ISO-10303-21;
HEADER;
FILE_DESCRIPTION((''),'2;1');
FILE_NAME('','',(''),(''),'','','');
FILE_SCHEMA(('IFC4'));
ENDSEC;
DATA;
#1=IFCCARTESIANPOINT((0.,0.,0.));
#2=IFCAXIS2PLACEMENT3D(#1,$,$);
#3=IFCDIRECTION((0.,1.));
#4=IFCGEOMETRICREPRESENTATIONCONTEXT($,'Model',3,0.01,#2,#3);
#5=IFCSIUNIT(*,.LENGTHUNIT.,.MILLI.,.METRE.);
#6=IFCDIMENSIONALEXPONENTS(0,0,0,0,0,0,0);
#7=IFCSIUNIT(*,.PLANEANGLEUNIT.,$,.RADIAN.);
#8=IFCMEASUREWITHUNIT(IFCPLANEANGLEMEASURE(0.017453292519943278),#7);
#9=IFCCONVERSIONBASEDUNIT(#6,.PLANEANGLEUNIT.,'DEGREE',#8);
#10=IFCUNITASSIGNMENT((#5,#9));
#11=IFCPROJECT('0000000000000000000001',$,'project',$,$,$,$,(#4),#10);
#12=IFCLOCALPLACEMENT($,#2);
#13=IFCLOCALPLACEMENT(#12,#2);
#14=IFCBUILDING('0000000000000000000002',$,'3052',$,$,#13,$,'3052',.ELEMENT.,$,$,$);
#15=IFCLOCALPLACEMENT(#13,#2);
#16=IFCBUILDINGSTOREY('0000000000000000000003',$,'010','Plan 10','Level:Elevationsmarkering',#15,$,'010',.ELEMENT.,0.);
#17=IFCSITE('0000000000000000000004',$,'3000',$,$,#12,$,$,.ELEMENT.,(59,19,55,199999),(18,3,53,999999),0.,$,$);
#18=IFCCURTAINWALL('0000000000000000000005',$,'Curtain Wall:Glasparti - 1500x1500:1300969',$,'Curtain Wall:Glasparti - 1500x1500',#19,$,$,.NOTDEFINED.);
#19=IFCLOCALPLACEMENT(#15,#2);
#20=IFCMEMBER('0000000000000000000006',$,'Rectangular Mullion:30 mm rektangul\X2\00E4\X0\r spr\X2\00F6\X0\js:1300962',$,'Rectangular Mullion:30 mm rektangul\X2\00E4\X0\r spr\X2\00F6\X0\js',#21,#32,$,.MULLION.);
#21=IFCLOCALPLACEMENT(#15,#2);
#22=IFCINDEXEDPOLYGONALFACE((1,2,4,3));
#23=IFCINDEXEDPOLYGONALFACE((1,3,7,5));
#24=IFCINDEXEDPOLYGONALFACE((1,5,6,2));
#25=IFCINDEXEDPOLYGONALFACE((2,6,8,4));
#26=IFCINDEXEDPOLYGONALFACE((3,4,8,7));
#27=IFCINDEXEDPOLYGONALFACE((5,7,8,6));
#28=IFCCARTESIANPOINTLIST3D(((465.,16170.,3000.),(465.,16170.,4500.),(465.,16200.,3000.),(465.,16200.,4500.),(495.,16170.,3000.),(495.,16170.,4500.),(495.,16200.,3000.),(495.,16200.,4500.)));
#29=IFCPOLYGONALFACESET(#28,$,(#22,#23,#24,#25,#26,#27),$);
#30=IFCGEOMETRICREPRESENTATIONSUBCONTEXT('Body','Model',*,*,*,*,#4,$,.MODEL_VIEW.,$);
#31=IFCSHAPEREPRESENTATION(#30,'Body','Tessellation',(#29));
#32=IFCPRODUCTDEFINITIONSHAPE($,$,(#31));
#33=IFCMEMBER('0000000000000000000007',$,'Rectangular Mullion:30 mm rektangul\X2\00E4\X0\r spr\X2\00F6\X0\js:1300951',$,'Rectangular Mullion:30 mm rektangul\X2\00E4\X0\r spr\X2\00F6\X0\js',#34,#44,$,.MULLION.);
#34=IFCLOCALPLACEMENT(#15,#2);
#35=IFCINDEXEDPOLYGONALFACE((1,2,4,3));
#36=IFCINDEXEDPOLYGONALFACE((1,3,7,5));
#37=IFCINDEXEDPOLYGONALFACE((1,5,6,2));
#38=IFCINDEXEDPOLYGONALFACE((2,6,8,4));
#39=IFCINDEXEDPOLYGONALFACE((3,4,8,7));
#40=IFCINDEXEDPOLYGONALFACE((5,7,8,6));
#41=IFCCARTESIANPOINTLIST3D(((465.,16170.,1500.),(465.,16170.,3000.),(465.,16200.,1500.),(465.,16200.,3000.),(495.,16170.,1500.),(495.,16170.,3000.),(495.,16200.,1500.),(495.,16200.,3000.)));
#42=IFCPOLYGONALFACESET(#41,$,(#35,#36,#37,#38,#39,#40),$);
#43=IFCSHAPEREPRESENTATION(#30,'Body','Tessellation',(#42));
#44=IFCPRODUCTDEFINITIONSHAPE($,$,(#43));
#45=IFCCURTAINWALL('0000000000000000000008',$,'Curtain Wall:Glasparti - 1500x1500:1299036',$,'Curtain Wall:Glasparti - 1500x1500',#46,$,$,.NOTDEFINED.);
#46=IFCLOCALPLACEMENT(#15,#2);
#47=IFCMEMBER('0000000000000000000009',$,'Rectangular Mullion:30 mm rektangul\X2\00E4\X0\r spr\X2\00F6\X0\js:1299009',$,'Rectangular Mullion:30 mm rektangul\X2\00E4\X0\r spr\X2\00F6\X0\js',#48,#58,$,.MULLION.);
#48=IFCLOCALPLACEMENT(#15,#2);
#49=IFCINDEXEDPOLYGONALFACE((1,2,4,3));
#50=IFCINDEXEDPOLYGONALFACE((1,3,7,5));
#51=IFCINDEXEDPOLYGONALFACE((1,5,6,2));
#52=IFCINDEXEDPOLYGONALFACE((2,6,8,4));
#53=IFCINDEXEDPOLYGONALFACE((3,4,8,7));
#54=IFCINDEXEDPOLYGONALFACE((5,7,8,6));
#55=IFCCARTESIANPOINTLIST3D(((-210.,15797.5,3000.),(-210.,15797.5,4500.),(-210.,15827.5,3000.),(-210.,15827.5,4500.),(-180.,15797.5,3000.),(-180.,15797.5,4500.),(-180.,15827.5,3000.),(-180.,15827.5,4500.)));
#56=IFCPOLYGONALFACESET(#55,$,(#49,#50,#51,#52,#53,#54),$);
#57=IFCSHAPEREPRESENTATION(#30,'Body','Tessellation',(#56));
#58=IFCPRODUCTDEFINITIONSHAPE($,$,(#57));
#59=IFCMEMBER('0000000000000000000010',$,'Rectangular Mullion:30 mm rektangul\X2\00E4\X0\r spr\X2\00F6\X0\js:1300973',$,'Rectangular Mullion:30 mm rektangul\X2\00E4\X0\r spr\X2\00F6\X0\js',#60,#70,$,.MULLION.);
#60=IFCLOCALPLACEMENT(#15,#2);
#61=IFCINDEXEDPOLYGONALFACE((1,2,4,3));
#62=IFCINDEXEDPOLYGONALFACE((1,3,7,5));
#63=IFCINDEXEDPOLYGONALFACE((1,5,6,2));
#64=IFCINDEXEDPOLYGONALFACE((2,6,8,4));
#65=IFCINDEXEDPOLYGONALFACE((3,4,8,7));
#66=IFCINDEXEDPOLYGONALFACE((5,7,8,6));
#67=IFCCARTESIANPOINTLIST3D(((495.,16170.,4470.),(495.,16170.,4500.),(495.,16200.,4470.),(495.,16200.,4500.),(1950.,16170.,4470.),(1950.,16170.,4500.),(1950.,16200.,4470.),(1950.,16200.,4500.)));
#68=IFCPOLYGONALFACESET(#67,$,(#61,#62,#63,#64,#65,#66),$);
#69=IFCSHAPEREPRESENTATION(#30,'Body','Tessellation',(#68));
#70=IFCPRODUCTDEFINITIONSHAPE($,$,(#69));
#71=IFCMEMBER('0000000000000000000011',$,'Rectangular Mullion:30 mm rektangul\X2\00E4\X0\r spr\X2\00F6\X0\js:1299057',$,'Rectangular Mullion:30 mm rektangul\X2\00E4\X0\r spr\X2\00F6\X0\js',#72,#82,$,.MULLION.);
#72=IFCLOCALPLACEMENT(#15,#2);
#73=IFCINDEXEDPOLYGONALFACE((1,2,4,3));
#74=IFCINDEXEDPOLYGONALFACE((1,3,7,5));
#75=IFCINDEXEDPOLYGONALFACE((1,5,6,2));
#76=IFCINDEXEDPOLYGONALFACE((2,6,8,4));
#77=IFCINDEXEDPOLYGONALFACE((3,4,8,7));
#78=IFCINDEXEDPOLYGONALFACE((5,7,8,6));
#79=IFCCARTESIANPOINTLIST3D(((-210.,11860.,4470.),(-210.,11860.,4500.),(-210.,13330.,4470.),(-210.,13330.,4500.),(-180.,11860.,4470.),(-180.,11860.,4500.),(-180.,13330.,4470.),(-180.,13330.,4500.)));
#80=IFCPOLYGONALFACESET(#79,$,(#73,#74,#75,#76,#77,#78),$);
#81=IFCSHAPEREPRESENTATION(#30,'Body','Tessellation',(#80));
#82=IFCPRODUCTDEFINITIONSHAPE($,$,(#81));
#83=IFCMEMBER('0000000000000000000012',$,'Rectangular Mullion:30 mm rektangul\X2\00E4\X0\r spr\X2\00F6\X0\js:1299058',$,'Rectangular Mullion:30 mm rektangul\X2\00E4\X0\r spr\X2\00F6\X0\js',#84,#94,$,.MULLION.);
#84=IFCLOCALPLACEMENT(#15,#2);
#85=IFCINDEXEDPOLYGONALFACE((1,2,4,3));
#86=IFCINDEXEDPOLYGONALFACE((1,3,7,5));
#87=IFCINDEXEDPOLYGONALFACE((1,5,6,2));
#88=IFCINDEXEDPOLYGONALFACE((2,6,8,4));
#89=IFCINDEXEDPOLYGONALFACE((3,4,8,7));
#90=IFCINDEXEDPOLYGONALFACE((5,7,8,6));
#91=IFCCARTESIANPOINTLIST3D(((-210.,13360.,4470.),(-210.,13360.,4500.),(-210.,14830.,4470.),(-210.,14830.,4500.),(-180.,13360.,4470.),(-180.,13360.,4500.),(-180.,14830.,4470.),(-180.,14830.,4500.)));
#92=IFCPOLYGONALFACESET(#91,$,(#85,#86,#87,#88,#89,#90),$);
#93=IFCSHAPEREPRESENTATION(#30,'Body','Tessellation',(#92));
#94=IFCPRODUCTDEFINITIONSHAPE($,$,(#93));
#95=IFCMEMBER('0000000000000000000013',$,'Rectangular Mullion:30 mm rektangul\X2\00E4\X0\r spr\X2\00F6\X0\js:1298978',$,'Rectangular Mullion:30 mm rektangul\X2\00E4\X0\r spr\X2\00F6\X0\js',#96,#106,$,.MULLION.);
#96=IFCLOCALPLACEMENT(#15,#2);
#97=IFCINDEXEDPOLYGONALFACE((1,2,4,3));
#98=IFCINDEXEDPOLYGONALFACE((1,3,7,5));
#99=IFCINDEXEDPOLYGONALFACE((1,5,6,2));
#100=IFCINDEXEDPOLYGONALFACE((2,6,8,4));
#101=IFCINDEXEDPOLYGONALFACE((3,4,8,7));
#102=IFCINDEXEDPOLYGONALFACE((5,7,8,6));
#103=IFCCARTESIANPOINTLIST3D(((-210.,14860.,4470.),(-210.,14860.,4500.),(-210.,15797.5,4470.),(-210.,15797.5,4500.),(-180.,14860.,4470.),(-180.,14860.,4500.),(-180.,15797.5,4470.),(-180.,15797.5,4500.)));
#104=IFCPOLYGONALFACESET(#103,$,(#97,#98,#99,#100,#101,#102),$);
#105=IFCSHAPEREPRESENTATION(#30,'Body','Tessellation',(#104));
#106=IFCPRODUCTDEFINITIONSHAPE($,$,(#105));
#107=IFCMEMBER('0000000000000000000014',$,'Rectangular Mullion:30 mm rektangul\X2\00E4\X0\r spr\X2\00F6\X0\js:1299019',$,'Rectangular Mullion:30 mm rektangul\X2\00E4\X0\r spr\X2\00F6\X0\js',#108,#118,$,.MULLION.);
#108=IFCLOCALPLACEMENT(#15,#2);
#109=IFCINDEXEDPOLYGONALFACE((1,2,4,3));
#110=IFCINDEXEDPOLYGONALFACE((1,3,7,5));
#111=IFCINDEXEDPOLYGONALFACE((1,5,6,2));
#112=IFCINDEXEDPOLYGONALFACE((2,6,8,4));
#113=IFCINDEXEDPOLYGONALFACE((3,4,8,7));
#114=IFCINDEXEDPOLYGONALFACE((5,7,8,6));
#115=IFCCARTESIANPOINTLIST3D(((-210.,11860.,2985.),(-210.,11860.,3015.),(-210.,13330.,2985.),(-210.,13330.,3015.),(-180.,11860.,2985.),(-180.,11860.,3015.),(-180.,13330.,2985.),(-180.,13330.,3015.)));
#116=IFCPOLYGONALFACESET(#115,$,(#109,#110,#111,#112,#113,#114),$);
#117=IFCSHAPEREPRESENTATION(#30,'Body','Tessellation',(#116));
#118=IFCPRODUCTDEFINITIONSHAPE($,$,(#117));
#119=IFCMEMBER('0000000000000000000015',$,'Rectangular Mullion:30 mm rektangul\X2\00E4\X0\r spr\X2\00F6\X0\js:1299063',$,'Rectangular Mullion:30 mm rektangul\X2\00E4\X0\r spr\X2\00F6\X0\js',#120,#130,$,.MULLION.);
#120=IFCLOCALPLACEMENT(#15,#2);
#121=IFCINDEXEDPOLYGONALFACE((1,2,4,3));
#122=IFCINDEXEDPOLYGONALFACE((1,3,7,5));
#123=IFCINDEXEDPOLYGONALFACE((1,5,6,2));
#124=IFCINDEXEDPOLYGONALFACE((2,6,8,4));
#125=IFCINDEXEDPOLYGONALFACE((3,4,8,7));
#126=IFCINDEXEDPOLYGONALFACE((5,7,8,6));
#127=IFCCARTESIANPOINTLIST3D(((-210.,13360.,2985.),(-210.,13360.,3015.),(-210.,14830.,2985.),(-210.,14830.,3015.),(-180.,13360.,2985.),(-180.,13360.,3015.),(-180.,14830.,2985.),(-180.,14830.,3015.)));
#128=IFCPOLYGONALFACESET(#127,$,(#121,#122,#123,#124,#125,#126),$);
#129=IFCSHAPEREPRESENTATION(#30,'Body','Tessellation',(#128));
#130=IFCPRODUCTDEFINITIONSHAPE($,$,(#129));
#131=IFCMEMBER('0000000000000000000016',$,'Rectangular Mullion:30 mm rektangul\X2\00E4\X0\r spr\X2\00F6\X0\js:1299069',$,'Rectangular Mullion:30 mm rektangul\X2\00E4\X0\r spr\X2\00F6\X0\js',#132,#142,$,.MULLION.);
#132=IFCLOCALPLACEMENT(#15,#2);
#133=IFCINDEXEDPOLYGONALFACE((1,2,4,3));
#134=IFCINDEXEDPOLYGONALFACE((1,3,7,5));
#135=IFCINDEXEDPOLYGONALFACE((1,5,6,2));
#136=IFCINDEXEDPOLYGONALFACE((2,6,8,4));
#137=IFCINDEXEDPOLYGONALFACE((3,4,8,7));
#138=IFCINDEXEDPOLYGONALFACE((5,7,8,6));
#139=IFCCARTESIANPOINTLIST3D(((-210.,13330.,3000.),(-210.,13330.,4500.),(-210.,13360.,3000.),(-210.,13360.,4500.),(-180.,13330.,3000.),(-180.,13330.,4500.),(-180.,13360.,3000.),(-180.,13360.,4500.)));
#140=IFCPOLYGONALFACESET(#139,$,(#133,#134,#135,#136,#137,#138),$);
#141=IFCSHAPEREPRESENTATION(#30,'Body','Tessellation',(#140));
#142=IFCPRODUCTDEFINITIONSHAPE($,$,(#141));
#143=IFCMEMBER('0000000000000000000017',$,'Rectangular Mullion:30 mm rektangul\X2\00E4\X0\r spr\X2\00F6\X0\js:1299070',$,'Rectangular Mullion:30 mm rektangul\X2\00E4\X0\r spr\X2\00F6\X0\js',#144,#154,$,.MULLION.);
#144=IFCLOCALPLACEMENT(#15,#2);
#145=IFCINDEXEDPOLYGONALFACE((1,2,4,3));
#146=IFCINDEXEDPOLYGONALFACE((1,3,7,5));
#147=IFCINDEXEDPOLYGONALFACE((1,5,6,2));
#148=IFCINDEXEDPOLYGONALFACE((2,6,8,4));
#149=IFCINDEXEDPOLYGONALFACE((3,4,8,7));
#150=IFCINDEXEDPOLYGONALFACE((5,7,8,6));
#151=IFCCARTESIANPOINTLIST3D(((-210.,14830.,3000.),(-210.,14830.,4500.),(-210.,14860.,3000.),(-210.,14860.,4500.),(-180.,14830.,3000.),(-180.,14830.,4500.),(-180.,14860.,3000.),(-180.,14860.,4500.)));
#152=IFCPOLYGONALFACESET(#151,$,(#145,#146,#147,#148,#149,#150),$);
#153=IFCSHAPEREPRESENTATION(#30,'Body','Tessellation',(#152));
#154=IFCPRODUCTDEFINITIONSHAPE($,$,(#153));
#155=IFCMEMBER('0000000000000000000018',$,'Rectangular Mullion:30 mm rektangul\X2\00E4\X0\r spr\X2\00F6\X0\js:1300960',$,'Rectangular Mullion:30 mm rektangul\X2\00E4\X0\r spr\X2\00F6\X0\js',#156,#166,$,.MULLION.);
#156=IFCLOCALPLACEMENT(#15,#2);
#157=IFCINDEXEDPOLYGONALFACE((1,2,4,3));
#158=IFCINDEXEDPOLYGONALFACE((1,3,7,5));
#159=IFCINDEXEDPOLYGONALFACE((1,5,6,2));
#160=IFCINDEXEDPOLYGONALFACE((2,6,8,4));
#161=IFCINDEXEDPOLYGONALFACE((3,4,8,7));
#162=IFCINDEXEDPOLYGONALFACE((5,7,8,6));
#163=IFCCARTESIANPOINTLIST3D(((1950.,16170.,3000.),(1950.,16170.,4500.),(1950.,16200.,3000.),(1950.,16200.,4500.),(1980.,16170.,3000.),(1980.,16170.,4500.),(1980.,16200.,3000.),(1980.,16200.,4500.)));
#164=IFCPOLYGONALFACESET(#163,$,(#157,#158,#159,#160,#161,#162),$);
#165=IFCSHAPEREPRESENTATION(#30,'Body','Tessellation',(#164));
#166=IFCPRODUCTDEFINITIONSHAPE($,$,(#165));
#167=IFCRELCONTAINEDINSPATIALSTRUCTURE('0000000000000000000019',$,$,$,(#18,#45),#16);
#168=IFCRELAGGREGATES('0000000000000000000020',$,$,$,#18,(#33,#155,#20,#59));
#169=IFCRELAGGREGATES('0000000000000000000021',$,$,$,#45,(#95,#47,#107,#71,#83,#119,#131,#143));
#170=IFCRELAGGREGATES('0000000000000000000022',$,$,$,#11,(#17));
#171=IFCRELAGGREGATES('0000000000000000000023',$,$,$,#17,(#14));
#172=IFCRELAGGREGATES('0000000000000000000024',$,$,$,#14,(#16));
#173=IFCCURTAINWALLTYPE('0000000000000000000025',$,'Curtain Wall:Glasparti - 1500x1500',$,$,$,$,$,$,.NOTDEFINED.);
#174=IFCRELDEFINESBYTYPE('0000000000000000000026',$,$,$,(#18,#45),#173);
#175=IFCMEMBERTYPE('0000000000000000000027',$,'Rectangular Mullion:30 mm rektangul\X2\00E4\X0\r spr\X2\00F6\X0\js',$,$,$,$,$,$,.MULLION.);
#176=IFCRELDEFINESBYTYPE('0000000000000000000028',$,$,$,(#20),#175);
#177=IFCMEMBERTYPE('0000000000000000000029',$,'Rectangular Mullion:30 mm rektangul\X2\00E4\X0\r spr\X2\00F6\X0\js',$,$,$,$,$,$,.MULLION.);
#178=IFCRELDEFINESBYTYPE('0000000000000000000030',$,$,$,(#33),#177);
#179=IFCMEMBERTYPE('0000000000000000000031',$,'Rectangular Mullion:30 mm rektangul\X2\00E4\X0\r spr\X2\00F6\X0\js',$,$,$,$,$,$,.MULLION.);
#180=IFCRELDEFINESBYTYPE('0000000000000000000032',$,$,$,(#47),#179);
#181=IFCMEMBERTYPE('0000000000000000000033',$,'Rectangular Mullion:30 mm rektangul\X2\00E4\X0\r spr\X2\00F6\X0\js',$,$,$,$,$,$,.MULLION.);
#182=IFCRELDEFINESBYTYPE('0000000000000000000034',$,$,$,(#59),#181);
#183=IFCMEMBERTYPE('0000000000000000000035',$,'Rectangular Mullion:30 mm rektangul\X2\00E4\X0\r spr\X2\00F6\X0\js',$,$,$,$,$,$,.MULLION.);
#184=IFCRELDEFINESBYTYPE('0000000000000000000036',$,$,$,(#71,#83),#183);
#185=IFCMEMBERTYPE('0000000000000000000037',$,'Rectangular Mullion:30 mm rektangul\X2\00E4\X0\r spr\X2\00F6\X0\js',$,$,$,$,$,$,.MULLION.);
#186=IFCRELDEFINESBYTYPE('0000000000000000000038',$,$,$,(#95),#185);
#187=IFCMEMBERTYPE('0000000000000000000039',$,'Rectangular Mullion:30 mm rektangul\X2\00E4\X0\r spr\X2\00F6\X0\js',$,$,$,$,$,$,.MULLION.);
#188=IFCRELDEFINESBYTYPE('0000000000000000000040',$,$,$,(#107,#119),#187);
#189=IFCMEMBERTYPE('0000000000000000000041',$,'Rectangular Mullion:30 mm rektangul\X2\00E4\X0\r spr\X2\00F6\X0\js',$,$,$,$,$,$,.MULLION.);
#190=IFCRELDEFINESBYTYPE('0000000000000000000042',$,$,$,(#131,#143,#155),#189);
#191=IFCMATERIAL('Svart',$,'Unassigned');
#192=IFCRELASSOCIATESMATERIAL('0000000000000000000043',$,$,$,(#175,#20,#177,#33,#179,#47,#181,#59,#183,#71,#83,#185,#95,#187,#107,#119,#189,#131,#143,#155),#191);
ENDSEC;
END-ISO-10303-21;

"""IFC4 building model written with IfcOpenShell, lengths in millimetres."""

from ifc_helpers import new_model, entity, si_unit, converted_unit, direction, frame, origin, place, context, subcontext, project, spatial, indexed_curve, outline, extrude, source, transform, mapped, material, type_object, type_shapes, element, aggregate, save


model = new_model("IFC4")

# Units and contexts
model_context = context("Model", 3, precision=0.01, world=origin(), true_north=direction((0.0, 1.0)))
body_context = subcontext(model_context, "Body", "Model", "MODEL_VIEW")
ifc_project = project(units=[si_unit("LENGTHUNIT", "METRE", prefix="MILLI"), converted_unit("PLANEANGLEUNIT", "DEGREE", entity("IfcPlaneAngleMeasure", 0.017453292519943278), si_unit("PLANEANGLEUNIT", "RADIAN"), dimensions=[0, 0, 0, 0, 0, 0, 0])], contexts=[model_context])

# Site, building, storey
site_placement = place(None, origin())
site = spatial("IfcSite", under=ifc_project, at=site_placement, Name="3000", CompositionType="ELEMENT", RefLatitude=(59, 19, 55, 199999), RefLongitude=(18, 3, 53, 999999), RefElevation=0.0)
building_placement = place(site_placement, origin())
building = spatial("IfcBuilding", under=site, at=building_placement, Name="3052", LongName="3052", CompositionType="ELEMENT")
storey_placement = place(building_placement, origin())
storey = spatial("IfcBuildingStorey", under=building, at=storey_placement, Name="010", Description="Plan 10", ObjectType="Level:Elevationsmarkering", LongName="010", CompositionType="ELEMENT", Elevation=0.0)

# Curtain wall, members
curtain_wall_type = type_object("IfcCurtainWallType", Name="Curtain Wall:Glasparti - 1500x1500", PredefinedType="NOTDEFINED")
curtain_wall_1_placement = place(storey_placement, origin())
curtain_wall_1 = element("IfcCurtainWall", 1, at=curtain_wall_1_placement, inside=storey, type_object=curtain_wall_type, Name="Curtain Wall:Glasparti - 1500x1500:1300969", ObjectType="Curtain Wall:Glasparti - 1500x1500", PredefinedType="NOTDEFINED")
ifc_material_1 = material(Name="Svart", Category="Unassigned")
member_type_1 = type_object("IfcMemberType", Name="Rectangular Mullion:30 mm rektangulär spröjs", PredefinedType="MULLION", material=ifc_material_1)
shared_shape_1 = source(origin(), body_context, "Body", "SweptSolid", [
    extrude(outline(indexed_curve([(-15.0, -15.0), (15.0, -15.0), (15.0, 15.0), (-15.0, 15.0), (-15.0, -15.0)], self_intersect=False)), frame((-15.0, 0.0, -1500.0), z_axis=(0.0, 0.0, 1.0), x_axis=(-1.0, 0.0, 0.0)), (0.0, 0.0, 1.0), 1500.0),
])
type_shapes(member_type_1, [shared_shape_1])
member_1_placement = place(curtain_wall_1_placement, frame((465.0, 16185.0, 4500.0), z_axis=(0.0, 0.0, 1.0), x_axis=(-1.0, 0.0, 0.0)))
member_1 = element("IfcMember", 2, at=member_1_placement, type_object=member_type_1, material=ifc_material_1, Name="Rectangular Mullion:30 mm rektangulär spröjs:1300962", ObjectType="Rectangular Mullion:30 mm rektangulär spröjs", PredefinedType="MULLION", context=body_context, shape_type="MappedRepresentation", body=[
    mapped(shared_shape_1, transform((0.0, 0.0, 0.0), scale=1.0)),
])
member_type_2 = type_object("IfcMemberType", Name="Rectangular Mullion:30 mm rektangulär spröjs", PredefinedType="MULLION", material=ifc_material_1)
shared_shape_2 = source(origin(), body_context, "Body", "SweptSolid", [
    extrude(outline(indexed_curve([(-15.0, -15.0), (15.0, -15.0), (15.0, 15.0), (-15.0, 15.0), (-15.0, -15.0)], self_intersect=False)), frame((-15.0, 0.0, -1500.0), z_axis=(0.0, 0.0, 1.0), x_axis=(-1.0, 0.0, 0.0)), (0.0, 0.0, 1.0), 1500.0),
])
type_shapes(member_type_2, [shared_shape_2])
member_2_placement = place(curtain_wall_1_placement, frame((465.0, 16185.0, 3000.0), z_axis=(0.0, 0.0, 1.0), x_axis=(-1.0, 0.0, 0.0)))
member_2 = element("IfcMember", 3, at=member_2_placement, type_object=member_type_2, material=ifc_material_1, Name="Rectangular Mullion:30 mm rektangulär spröjs:1300951", ObjectType="Rectangular Mullion:30 mm rektangulär spröjs", PredefinedType="MULLION", context=body_context, shape_type="MappedRepresentation", body=[
    mapped(shared_shape_2, transform((0.0, 0.0, 0.0), scale=1.0)),
])

# Curtain wall, member
curtain_wall_2_placement = place(storey_placement, origin())
curtain_wall_2 = element("IfcCurtainWall", 4, at=curtain_wall_2_placement, inside=storey, type_object=curtain_wall_type, Name="Curtain Wall:Glasparti - 1500x1500:1299036", ObjectType="Curtain Wall:Glasparti - 1500x1500", PredefinedType="NOTDEFINED")
member_type_3 = type_object("IfcMemberType", Name="Rectangular Mullion:30 mm rektangulär spröjs", PredefinedType="MULLION", material=ifc_material_1)
shared_shape_3 = source(origin(), body_context, "Body", "SweptSolid", [
    extrude(outline(indexed_curve([(-15.0, -15.0), (15.0, -15.0), (15.0, 15.0), (-15.0, 15.0), (-15.0, -15.0)], self_intersect=False)), frame((-15.0, 0.0, -1500.0), z_axis=(0.0, 0.0, 1.0), x_axis=(-1.0, 0.0, 0.0)), (0.0, 0.0, 1.0), 1500.0),
])
type_shapes(member_type_3, [shared_shape_3])
member_3_placement = place(curtain_wall_2_placement, frame((-195.0, 15827.5, 3000.0), z_axis=(0.0, 0.0, -1.0), x_axis=(0.0, 1.0, 0.0)))
member_3 = element("IfcMember", 5, at=member_3_placement, type_object=member_type_3, material=ifc_material_1, Name="Rectangular Mullion:30 mm rektangulär spröjs:1299009", ObjectType="Rectangular Mullion:30 mm rektangulär spröjs", PredefinedType="MULLION", context=body_context, shape_type="MappedRepresentation", body=[
    mapped(shared_shape_3, transform((0.0, 0.0, 0.0), scale=1.0)),
])

# Members
member_type_4 = type_object("IfcMemberType", Name="Rectangular Mullion:30 mm rektangulär spröjs", PredefinedType="MULLION", material=ifc_material_1)
shared_shape_4 = source(origin(), body_context, "Body", "SweptSolid", [
    extrude(outline(indexed_curve([(-15.0, -15.0), (15.0, -15.0), (15.0, 15.0), (-15.0, 15.0), (-15.0, -15.0)], self_intersect=False)), frame((-15.0, 0.0, -1455.0), z_axis=(0.0, 0.0, 1.0), x_axis=(-1.0, 0.0, 0.0)), (0.0, 0.0, 1.0), 1455.0),
])
type_shapes(member_type_4, [shared_shape_4])
member_4_placement = place(curtain_wall_1_placement, frame((1950.0, 16185.0, 4500.0), z_axis=(1.0, 0.0, 0.0), x_axis=(0.0, 0.0, 1.0)))
member_4 = element("IfcMember", 6, at=member_4_placement, type_object=member_type_4, material=ifc_material_1, Name="Rectangular Mullion:30 mm rektangulär spröjs:1300973", ObjectType="Rectangular Mullion:30 mm rektangulär spröjs", PredefinedType="MULLION", context=body_context, shape_type="MappedRepresentation", body=[
    mapped(shared_shape_4, transform((0.0, 0.0, 0.0), scale=1.0)),
])
member_type_5 = type_object("IfcMemberType", Name="Rectangular Mullion:30 mm rektangulär spröjs", PredefinedType="MULLION", material=ifc_material_1)
shared_shape_5 = source(origin(), body_context, "Body", "SweptSolid", [
    extrude(outline(indexed_curve([(-15.0, -15.0), (15.0, -15.0), (15.0, 15.0), (-15.0, 15.0), (-15.0, -15.0)], self_intersect=False)), frame((-15.0, 0.0, -1470.0), z_axis=(0.0, 0.0, 1.0), x_axis=(-1.0, 0.0, 0.0)), (0.0, 0.0, 1.0), 1470.0),
])
type_shapes(member_type_5, [shared_shape_5])
member_5_placement = place(curtain_wall_2_placement, frame((-195.0, 13330.0, 4500.0), z_axis=(0.0, 1.0, 0.0), x_axis=(0.0, 0.0, 1.0)))
member_5 = element("IfcMember", 7, at=member_5_placement, type_object=member_type_5, material=ifc_material_1, Name="Rectangular Mullion:30 mm rektangulär spröjs:1299057", ObjectType="Rectangular Mullion:30 mm rektangulär spröjs", PredefinedType="MULLION", context=body_context, shape_type="MappedRepresentation", body=[
    mapped(shared_shape_5, transform((0.0, 0.0, 0.0), scale=1.0)),
])
member_6_placement = place(curtain_wall_2_placement, frame((-195.0, 14830.0, 4500.0), z_axis=(0.0, 1.0, 0.0), x_axis=(0.0, 0.0, 1.0)))
member_6 = element("IfcMember", 8, at=member_6_placement, type_object=member_type_5, material=ifc_material_1, Name="Rectangular Mullion:30 mm rektangulär spröjs:1299058", ObjectType="Rectangular Mullion:30 mm rektangulär spröjs", PredefinedType="MULLION", context=body_context, shape_type="MappedRepresentation", body=[
    mapped(shared_shape_5, transform((0.0, 0.0, 0.0), scale=1.0)),
])
member_type_6 = type_object("IfcMemberType", Name="Rectangular Mullion:30 mm rektangulär spröjs", PredefinedType="MULLION", material=ifc_material_1)
shared_shape_6 = source(origin(), body_context, "Body", "SweptSolid", [
    extrude(outline(indexed_curve([(-15.0, -15.0), (15.0, -15.0), (15.0, 15.0), (-15.0, 15.0), (-15.0, -15.0)], self_intersect=False)), frame((-15.0, 0.0, -937.5), z_axis=(0.0, 0.0, 1.0), x_axis=(-1.0, 0.0, 0.0)), (0.0, 0.0, 1.0), 937.5),
])
type_shapes(member_type_6, [shared_shape_6])
member_7_placement = place(curtain_wall_2_placement, frame((-195.0, 15797.5, 4500.0), z_axis=(0.0, 1.0, 0.0), x_axis=(0.0, 0.0, 1.0)))
member_7 = element("IfcMember", 9, at=member_7_placement, type_object=member_type_6, material=ifc_material_1, Name="Rectangular Mullion:30 mm rektangulär spröjs:1298978", ObjectType="Rectangular Mullion:30 mm rektangulär spröjs", PredefinedType="MULLION", context=body_context, shape_type="MappedRepresentation", body=[
    mapped(shared_shape_6, transform((0.0, 0.0, 0.0), scale=1.0)),
])
member_type_7 = type_object("IfcMemberType", Name="Rectangular Mullion:30 mm rektangulär spröjs", PredefinedType="MULLION", material=ifc_material_1)
shared_shape_7 = source(origin(), body_context, "Body", "SweptSolid", [
    extrude(outline(indexed_curve([(-15.0, -15.0), (15.0, -15.0), (15.0, 15.0), (-15.0, 15.0), (-15.0, -15.0)], self_intersect=False)), frame((0.0, 0.0, -1470.0), z_axis=(0.0, 0.0, 1.0), x_axis=(-1.0, 0.0, 0.0)), (0.0, 0.0, 1.0), 1470.0),
])
type_shapes(member_type_7, [shared_shape_7])
member_8_placement = place(curtain_wall_2_placement, frame((-195.0, 13330.0, 3000.0), z_axis=(0.0, 1.0, 0.0), x_axis=(0.0, 0.0, 1.0)))
member_8 = element("IfcMember", 10, at=member_8_placement, type_object=member_type_7, material=ifc_material_1, Name="Rectangular Mullion:30 mm rektangulär spröjs:1299019", ObjectType="Rectangular Mullion:30 mm rektangulär spröjs", PredefinedType="MULLION", context=body_context, shape_type="MappedRepresentation", body=[
    mapped(shared_shape_7, transform((0.0, 0.0, 0.0), scale=1.0)),
])
member_9_placement = place(curtain_wall_2_placement, frame((-195.0, 14830.0, 3000.0), z_axis=(0.0, 1.0, 0.0), x_axis=(0.0, 0.0, 1.0)))
member_9 = element("IfcMember", 11, at=member_9_placement, type_object=member_type_7, material=ifc_material_1, Name="Rectangular Mullion:30 mm rektangulär spröjs:1299063", ObjectType="Rectangular Mullion:30 mm rektangulär spröjs", PredefinedType="MULLION", context=body_context, shape_type="MappedRepresentation", body=[
    mapped(shared_shape_7, transform((0.0, 0.0, 0.0), scale=1.0)),
])
member_type_8 = type_object("IfcMemberType", Name="Rectangular Mullion:30 mm rektangulär spröjs", PredefinedType="MULLION", material=ifc_material_1)
shared_shape_8 = source(origin(), body_context, "Body", "SweptSolid", [
    extrude(outline(indexed_curve([(-15.0, -15.0), (15.0, -15.0), (15.0, 15.0), (-15.0, 15.0), (-15.0, -15.0)], self_intersect=False)), frame((0.0, 0.0, -1500.0), z_axis=(0.0, 0.0, 1.0), x_axis=(-1.0, 0.0, 0.0)), (0.0, 0.0, 1.0), 1500.0),
])
type_shapes(member_type_8, [shared_shape_8])
member_10_placement = place(curtain_wall_2_placement, frame((-195.0, 13345.0, 3000.0), z_axis=(0.0, 0.0, -1.0), x_axis=(0.0, 1.0, 0.0)))
member_10 = element("IfcMember", 12, at=member_10_placement, type_object=member_type_8, material=ifc_material_1, Name="Rectangular Mullion:30 mm rektangulär spröjs:1299069", ObjectType="Rectangular Mullion:30 mm rektangulär spröjs", PredefinedType="MULLION", context=body_context, shape_type="MappedRepresentation", body=[
    mapped(shared_shape_8, transform((0.0, 0.0, 0.0), scale=1.0)),
])
member_11_placement = place(curtain_wall_2_placement, frame((-195.0, 14845.0, 3000.0), z_axis=(0.0, 0.0, -1.0), x_axis=(0.0, 1.0, 0.0)))
member_11 = element("IfcMember", 13, at=member_11_placement, type_object=member_type_8, material=ifc_material_1, Name="Rectangular Mullion:30 mm rektangulär spröjs:1299070", ObjectType="Rectangular Mullion:30 mm rektangulär spröjs", PredefinedType="MULLION", context=body_context, shape_type="MappedRepresentation", body=[
    mapped(shared_shape_8, transform((0.0, 0.0, 0.0), scale=1.0)),
])
member_12_placement = place(curtain_wall_1_placement, frame((1965.0, 16185.0, 3000.0), z_axis=(0.0, 0.0, -1.0), x_axis=(1.0, 0.0, 0.0)))
member_12 = element("IfcMember", 14, at=member_12_placement, type_object=member_type_8, material=ifc_material_1, Name="Rectangular Mullion:30 mm rektangulär spröjs:1300960", ObjectType="Rectangular Mullion:30 mm rektangulär spröjs", PredefinedType="MULLION", context=body_context, shape_type="MappedRepresentation", body=[
    mapped(shared_shape_8, transform((0.0, 0.0, 0.0), scale=1.0)),
])

aggregate(curtain_wall_1, [member_2, member_12, member_1, member_4])
aggregate(curtain_wall_2, [member_7, member_3, member_8, member_5, member_6, member_9, member_10, member_11])

save(model, "model.ifc")
